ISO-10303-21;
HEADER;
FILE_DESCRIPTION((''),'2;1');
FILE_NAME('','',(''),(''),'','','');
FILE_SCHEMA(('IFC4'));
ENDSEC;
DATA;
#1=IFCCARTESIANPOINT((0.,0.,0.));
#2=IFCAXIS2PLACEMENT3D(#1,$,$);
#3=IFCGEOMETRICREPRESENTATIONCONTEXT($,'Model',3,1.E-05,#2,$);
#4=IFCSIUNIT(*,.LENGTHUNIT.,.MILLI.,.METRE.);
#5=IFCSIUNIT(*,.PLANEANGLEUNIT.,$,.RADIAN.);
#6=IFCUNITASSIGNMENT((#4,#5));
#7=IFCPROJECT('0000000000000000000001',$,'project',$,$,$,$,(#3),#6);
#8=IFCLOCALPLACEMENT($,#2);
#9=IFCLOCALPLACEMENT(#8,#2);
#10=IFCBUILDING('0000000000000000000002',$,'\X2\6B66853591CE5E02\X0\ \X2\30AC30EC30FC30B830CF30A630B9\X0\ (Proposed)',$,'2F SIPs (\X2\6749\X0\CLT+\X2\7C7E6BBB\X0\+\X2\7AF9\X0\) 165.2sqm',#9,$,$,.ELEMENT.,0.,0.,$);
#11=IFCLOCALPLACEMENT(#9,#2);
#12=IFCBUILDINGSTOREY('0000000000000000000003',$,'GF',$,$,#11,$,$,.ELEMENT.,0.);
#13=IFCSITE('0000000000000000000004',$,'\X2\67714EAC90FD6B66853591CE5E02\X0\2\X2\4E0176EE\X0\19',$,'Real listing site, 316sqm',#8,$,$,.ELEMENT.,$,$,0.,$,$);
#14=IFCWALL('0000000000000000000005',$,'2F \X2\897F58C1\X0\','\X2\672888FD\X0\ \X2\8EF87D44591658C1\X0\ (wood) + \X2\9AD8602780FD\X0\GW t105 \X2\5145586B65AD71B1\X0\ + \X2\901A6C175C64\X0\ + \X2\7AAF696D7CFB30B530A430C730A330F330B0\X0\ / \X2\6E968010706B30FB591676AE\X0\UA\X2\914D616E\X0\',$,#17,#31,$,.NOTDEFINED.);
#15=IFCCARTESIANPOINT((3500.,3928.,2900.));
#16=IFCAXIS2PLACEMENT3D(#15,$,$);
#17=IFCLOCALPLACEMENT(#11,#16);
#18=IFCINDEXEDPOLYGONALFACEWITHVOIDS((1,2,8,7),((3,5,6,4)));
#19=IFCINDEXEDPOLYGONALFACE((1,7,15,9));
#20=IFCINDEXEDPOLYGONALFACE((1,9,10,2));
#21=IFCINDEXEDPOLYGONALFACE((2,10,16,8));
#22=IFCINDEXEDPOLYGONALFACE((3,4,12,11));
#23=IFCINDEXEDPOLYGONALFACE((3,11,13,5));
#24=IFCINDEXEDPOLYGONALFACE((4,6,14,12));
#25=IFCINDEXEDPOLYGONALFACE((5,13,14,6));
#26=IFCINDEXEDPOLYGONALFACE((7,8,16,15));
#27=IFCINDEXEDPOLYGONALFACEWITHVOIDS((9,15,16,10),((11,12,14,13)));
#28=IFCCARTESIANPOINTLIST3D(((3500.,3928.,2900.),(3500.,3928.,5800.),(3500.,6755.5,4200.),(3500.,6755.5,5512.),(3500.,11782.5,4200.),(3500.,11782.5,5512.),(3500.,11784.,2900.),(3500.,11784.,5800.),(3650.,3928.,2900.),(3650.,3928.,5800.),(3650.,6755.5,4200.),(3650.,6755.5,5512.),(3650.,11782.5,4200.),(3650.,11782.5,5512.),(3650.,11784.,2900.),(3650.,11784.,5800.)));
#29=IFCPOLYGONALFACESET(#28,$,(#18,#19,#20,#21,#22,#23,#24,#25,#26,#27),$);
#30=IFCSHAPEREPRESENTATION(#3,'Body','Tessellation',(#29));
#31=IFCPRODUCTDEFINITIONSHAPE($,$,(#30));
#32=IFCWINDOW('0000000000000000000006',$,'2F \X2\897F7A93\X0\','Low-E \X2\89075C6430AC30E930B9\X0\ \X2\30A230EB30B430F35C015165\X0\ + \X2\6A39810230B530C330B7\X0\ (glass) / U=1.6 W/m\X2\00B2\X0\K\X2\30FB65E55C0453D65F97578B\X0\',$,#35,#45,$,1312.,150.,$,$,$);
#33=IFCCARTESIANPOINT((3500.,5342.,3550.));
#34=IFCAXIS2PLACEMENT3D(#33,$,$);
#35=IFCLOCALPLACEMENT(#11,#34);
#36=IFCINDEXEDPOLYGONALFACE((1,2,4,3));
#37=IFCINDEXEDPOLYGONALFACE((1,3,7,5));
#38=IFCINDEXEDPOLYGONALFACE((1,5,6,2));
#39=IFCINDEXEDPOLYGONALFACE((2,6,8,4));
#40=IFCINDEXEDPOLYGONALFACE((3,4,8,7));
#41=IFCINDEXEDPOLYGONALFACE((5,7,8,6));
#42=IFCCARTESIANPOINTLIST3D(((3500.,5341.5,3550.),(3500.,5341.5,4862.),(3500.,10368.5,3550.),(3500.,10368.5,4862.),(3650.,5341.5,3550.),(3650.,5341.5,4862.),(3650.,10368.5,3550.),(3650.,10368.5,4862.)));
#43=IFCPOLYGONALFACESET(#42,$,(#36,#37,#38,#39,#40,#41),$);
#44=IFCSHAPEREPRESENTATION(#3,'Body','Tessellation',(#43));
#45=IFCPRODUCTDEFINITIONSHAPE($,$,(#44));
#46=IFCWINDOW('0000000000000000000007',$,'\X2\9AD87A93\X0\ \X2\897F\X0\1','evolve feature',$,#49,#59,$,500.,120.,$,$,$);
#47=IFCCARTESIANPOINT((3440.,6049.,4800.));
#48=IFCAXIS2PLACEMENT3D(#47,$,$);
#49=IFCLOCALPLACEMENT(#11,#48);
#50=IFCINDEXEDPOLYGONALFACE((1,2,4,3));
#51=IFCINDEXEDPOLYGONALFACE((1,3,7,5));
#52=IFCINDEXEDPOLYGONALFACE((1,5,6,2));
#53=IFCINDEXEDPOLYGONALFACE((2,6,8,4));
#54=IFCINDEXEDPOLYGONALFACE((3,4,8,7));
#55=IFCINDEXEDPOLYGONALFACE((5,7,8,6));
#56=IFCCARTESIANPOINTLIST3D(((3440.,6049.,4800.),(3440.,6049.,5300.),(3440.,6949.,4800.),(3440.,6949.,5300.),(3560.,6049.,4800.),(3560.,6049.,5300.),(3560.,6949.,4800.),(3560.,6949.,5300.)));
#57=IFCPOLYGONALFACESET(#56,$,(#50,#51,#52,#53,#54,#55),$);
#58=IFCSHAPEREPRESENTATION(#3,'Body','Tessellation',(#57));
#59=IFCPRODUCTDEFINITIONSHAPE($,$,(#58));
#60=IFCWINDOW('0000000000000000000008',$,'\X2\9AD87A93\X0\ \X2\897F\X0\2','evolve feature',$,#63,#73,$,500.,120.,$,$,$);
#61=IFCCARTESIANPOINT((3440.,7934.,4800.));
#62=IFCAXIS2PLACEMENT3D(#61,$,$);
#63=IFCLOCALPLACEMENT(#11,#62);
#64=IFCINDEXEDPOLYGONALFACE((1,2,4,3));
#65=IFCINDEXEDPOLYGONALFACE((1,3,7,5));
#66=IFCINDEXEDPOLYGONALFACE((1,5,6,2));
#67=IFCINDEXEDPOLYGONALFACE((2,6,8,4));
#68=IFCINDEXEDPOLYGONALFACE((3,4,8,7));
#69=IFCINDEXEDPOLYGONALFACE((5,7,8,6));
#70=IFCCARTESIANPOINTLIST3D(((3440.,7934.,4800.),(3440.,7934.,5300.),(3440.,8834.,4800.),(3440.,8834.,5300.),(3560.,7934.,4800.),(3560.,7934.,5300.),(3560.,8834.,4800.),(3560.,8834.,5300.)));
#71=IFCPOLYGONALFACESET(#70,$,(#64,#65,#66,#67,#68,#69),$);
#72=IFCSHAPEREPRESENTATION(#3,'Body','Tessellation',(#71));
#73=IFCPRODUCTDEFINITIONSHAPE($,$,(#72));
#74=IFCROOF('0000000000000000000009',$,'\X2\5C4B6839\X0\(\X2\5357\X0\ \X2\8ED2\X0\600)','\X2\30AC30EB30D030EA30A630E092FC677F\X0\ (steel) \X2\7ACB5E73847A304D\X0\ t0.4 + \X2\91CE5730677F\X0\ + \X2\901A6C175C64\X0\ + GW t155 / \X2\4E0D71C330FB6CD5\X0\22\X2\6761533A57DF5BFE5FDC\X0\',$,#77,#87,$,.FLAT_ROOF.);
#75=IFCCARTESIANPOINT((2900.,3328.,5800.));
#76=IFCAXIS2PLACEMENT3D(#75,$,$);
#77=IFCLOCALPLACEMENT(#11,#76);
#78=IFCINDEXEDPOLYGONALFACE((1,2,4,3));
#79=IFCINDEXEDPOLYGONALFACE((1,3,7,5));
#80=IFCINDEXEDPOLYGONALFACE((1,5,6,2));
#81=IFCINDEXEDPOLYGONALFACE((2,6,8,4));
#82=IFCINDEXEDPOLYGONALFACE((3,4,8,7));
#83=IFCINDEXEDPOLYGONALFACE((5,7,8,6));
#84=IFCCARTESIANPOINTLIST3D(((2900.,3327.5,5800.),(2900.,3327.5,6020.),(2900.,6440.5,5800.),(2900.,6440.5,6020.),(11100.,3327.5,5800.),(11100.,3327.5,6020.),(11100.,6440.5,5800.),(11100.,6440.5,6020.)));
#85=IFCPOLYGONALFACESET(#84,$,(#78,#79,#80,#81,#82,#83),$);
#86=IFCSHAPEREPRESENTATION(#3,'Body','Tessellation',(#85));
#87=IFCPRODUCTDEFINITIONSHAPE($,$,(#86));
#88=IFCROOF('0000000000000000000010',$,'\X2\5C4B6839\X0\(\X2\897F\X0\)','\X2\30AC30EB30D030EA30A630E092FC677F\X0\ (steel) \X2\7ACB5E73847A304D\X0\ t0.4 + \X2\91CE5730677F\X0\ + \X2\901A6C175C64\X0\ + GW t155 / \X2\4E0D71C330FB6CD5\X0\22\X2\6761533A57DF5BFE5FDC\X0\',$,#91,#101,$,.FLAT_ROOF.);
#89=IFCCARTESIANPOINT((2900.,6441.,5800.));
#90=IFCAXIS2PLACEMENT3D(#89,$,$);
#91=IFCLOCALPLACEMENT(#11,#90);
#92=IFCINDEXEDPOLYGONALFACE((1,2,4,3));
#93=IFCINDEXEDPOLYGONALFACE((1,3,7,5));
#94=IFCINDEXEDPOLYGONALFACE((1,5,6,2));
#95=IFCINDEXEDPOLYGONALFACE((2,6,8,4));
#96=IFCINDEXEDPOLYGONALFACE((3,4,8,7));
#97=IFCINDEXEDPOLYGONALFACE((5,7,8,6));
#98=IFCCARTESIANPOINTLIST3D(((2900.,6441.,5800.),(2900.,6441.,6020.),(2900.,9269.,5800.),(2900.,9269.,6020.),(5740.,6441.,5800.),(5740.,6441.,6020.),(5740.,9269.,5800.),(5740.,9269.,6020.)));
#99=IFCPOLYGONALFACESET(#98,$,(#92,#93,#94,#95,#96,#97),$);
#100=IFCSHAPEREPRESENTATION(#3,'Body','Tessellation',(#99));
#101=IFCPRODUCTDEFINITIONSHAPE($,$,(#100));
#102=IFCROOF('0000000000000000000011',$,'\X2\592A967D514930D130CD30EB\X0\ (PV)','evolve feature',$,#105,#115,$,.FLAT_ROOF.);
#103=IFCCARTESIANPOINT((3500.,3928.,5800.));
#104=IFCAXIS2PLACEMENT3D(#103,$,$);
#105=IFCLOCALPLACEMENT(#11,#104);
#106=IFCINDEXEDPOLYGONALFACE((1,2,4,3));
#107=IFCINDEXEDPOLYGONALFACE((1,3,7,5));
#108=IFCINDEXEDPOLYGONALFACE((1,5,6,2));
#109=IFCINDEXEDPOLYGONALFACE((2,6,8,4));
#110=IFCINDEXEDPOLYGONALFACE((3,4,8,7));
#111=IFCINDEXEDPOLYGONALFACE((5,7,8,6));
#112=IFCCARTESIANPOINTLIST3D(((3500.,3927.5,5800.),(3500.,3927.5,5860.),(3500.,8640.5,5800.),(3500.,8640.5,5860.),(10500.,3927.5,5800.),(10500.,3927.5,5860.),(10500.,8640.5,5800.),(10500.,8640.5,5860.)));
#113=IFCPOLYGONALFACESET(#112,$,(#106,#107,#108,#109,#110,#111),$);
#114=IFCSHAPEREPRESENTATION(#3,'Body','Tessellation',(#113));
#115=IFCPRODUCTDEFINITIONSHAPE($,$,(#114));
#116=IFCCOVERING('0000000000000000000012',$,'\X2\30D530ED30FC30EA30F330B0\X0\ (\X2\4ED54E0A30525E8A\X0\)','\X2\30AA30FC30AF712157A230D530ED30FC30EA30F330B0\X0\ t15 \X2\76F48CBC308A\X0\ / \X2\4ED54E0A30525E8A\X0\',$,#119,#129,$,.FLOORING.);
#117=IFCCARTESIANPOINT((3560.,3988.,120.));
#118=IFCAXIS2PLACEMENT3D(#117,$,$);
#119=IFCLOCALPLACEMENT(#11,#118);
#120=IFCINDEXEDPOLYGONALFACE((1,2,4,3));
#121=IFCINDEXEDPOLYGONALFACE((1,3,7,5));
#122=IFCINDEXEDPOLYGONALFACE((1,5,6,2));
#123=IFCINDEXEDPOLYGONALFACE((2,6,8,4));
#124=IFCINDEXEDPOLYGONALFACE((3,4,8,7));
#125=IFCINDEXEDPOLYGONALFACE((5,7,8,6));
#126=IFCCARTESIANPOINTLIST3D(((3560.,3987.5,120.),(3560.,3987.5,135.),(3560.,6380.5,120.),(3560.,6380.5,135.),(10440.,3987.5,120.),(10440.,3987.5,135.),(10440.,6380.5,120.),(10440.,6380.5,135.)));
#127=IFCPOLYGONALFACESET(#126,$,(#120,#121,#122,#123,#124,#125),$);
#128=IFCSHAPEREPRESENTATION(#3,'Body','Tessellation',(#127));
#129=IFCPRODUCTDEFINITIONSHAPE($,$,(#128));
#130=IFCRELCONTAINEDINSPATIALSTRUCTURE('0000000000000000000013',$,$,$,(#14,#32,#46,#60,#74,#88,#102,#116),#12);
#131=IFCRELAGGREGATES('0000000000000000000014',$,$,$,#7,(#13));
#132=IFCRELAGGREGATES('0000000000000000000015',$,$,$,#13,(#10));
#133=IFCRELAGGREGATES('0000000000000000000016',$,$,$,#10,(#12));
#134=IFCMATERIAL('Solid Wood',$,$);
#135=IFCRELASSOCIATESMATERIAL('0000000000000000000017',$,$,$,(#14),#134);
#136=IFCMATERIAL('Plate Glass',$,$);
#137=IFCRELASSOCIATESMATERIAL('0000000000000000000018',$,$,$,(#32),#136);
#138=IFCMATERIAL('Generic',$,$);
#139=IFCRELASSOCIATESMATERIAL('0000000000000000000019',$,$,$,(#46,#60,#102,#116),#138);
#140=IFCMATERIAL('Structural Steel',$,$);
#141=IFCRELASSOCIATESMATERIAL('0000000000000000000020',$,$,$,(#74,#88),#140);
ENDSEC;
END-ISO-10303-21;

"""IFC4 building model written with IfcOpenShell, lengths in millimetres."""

from ifc_helpers import new_model, si_unit, frame, frame_2d, origin, place, context, project, spatial, rectangle, extrude, material, element, fill, save


model = new_model("IFC4")

# Units and contexts
model_context = context("Model", 3, precision=1e-05, world=origin())
ifc_project = project(units=[si_unit("LENGTHUNIT", "METRE", prefix="MILLI"), si_unit("PLANEANGLEUNIT", "RADIAN")], contexts=[model_context])

# Site, building, storey
site_placement = place(None, origin())
site = spatial("IfcSite", under=ifc_project, at=site_placement, Name="東京都武蔵野市2丁目19", ObjectType="Real listing site, 316sqm", CompositionType="ELEMENT", RefElevation=0.0)
building_placement = place(site_placement, origin())
building = spatial("IfcBuilding", under=site, at=building_placement, Name="武蔵野市 ガレージハウス (Proposed)", ObjectType="2F SIPs (杉CLT+籾殻+竹) 165.2sqm", CompositionType="ELEMENT", ElevationOfRefHeight=0.0, ElevationOfTerrain=0.0)
storey_placement = place(building_placement, origin())
storey = spatial("IfcBuildingStorey", under=building, at=storey_placement, Name="GF", CompositionType="ELEMENT", Elevation=0.0)

# Shared definitions
ifc_material_1 = material(Name="Solid Wood")
ifc_material_2 = material(Name="Generic")

# Shared definitions
ifc_material_3 = material(Name="Plate Glass")

# Wall, openings, windows
wall_1_placement = place(storey_placement, frame((3500.0, 3928.0, 2900.0)))
wall_1 = element("IfcWall", 1, at=wall_1_placement, inside=storey, material=ifc_material_1, Name="2F 西壁", Description="木製 軸組外壁 (wood) + 高性能GW t105 充填断熱 + 通気層 + 窯業系サイディング / 準耐火・外皮UA配慮", PredefinedType="NOTDEFINED", context=model_context, shape_type="SweptSolid", body=[
    extrude(rectangle(XDim=150.0, YDim=7856.0, at=frame_2d((75.0, 3928.0))), frame((3500.0, 3928.0, 2900.0)), (0.0, 0.0, 1.0), 2900.0),
])
opening_1_placement = place(storey_placement, frame((3500.0, 5342.0, 3550.0)))
opening_1 = element("IfcOpeningElement", 2, at=opening_1_placement, cuts=wall_1, PredefinedType="NOTDEFINED", context=model_context, shape_type="SweptSolid", body=[
    extrude(rectangle(XDim=150.0, YDim=5027.0, at=frame_2d((75.0, 2513.0))), frame((3500.0, 5342.0, 3550.0)), (0.0, 0.0, 1.0), 1312.0),
])
opening_2_placement = place(storey_placement, frame((3440.0, 6049.0, 4800.0)))
opening_2 = element("IfcOpeningElement", 3, at=opening_2_placement, cuts=wall_1, PredefinedType="NOTDEFINED", context=model_context, shape_type="SweptSolid", body=[
    extrude(rectangle(XDim=120.0, YDim=900.0, at=frame_2d((60.0, 450.0))), frame((3440.0, 6049.0, 4800.0)), (0.0, 0.0, 1.0), 500.0),
])
opening_3_placement = place(storey_placement, frame((3440.0, 7934.0, 4800.0)))
opening_3 = element("IfcOpeningElement", 4, at=opening_3_placement, cuts=wall_1, PredefinedType="NOTDEFINED", context=model_context, shape_type="SweptSolid", body=[
    extrude(rectangle(XDim=120.0, YDim=900.0, at=frame_2d((60.0, 450.0))), frame((3440.0, 7934.0, 4800.0)), (0.0, 0.0, 1.0), 500.0),
])
window_1_placement = place(storey_placement, frame((3500.0, 5342.0, 3550.0)))
window_1 = element("IfcWindow", 5, at=window_1_placement, inside=storey, material=ifc_material_3, Name="2F 西窓", Description="Low-E 複層ガラス アルゴン封入 + 樹脂サッシ (glass) / U=1.6 W/m²K・日射取得型", OverallHeight=1312.0, OverallWidth=150.0, context=model_context, shape_type="SweptSolid", body=[
    extrude(rectangle(XDim=150.0, YDim=5027.0, at=frame_2d((75.0, 2513.0))), frame((3500.0, 5342.0, 3550.0)), (0.0, 0.0, 1.0), 1312.0),
])
fill(opening_1, window_1)
window_2_placement = place(storey_placement, frame((3440.0, 6049.0, 4800.0)))
window_2 = element("IfcWindow", 6, at=window_2_placement, inside=storey, material=ifc_material_2, Name="高窓 西1", Description="evolve feature", OverallHeight=500.0, OverallWidth=120.0, context=model_context, shape_type="SweptSolid", body=[
    extrude(rectangle(XDim=120.0, YDim=900.0, at=frame_2d((60.0, 450.0))), frame((3440.0, 6049.0, 4800.0)), (0.0, 0.0, 1.0), 500.0),
])
fill(opening_2, window_2)
window_3_placement = place(storey_placement, frame((3440.0, 7934.0, 4800.0)))
window_3 = element("IfcWindow", 7, at=window_3_placement, inside=storey, material=ifc_material_2, Name="高窓 西2", Description="evolve feature", OverallHeight=500.0, OverallWidth=120.0, context=model_context, shape_type="SweptSolid", body=[
    extrude(rectangle(XDim=120.0, YDim=900.0, at=frame_2d((60.0, 450.0))), frame((3440.0, 7934.0, 4800.0)), (0.0, 0.0, 1.0), 500.0),
])
fill(opening_3, window_3)

# Roofs
ifc_material_4 = material(Name="Structural Steel")
roof_1_placement = place(storey_placement, frame((2900.0, 3328.0, 5800.0)))
element("IfcRoof", 8, at=roof_1_placement, inside=storey, material=ifc_material_4, Name="屋根(南 軒600)", Description="ガルバリウム鋼板 (steel) 立平葺き t0.4 + 野地板 + 通気層 + GW t155 / 不燃・法22条区域対応", PredefinedType="FLAT_ROOF", context=model_context, shape_type="SweptSolid", body=[
    extrude(rectangle(XDim=8200.0, YDim=3113.0, at=frame_2d((4100.0, 1556.0))), frame((2900.0, 3328.0, 5800.0)), (0.0, 0.0, 1.0), 220.0),
])
roof_2_placement = place(storey_placement, frame((2900.0, 6441.0, 5800.0)))
element("IfcRoof", 9, at=roof_2_placement, inside=storey, material=ifc_material_4, Name="屋根(西)", Description="ガルバリウム鋼板 (steel) 立平葺き t0.4 + 野地板 + 通気層 + GW t155 / 不燃・法22条区域対応", PredefinedType="FLAT_ROOF", context=model_context, shape_type="SweptSolid", body=[
    extrude(rectangle(XDim=2840.0, YDim=2828.0, at=frame_2d((1420.0, 1414.0))), frame((2900.0, 6441.0, 5800.0)), (0.0, 0.0, 1.0), 220.0),
])
roof_3_placement = place(storey_placement, frame((3500.0, 3928.0, 5800.0)))
element("IfcRoof", 10, at=roof_3_placement, inside=storey, material=ifc_material_2, Name="太陽光パネル (PV)", Description="evolve feature", PredefinedType="FLAT_ROOF", context=model_context, shape_type="SweptSolid", body=[
    extrude(rectangle(XDim=7000.0, YDim=4713.0, at=frame_2d((3500.0, 2356.0))), frame((3500.0, 3928.0, 5800.0)), (0.0, 0.0, 1.0), 60.0),
])

# Covering
covering_placement = place(storey_placement, frame((3560.0, 3988.0, 120.0)))
element("IfcCovering", 11, at=covering_placement, inside=storey, material=ifc_material_2, Name="フローリング (仕上げ床)", Description="オーク無垢フローリング t15 直貼り / 仕上げ床", PredefinedType="FLOORING", context=model_context, shape_type="SweptSolid", body=[
    extrude(rectangle(XDim=6880.0, YDim=2393.0, at=frame_2d((3440.0, 1196.0))), frame((3560.0, 3988.0, 120.0)), (0.0, 0.0, 1.0), 15.0),
])

save(model, "model.ifc")
